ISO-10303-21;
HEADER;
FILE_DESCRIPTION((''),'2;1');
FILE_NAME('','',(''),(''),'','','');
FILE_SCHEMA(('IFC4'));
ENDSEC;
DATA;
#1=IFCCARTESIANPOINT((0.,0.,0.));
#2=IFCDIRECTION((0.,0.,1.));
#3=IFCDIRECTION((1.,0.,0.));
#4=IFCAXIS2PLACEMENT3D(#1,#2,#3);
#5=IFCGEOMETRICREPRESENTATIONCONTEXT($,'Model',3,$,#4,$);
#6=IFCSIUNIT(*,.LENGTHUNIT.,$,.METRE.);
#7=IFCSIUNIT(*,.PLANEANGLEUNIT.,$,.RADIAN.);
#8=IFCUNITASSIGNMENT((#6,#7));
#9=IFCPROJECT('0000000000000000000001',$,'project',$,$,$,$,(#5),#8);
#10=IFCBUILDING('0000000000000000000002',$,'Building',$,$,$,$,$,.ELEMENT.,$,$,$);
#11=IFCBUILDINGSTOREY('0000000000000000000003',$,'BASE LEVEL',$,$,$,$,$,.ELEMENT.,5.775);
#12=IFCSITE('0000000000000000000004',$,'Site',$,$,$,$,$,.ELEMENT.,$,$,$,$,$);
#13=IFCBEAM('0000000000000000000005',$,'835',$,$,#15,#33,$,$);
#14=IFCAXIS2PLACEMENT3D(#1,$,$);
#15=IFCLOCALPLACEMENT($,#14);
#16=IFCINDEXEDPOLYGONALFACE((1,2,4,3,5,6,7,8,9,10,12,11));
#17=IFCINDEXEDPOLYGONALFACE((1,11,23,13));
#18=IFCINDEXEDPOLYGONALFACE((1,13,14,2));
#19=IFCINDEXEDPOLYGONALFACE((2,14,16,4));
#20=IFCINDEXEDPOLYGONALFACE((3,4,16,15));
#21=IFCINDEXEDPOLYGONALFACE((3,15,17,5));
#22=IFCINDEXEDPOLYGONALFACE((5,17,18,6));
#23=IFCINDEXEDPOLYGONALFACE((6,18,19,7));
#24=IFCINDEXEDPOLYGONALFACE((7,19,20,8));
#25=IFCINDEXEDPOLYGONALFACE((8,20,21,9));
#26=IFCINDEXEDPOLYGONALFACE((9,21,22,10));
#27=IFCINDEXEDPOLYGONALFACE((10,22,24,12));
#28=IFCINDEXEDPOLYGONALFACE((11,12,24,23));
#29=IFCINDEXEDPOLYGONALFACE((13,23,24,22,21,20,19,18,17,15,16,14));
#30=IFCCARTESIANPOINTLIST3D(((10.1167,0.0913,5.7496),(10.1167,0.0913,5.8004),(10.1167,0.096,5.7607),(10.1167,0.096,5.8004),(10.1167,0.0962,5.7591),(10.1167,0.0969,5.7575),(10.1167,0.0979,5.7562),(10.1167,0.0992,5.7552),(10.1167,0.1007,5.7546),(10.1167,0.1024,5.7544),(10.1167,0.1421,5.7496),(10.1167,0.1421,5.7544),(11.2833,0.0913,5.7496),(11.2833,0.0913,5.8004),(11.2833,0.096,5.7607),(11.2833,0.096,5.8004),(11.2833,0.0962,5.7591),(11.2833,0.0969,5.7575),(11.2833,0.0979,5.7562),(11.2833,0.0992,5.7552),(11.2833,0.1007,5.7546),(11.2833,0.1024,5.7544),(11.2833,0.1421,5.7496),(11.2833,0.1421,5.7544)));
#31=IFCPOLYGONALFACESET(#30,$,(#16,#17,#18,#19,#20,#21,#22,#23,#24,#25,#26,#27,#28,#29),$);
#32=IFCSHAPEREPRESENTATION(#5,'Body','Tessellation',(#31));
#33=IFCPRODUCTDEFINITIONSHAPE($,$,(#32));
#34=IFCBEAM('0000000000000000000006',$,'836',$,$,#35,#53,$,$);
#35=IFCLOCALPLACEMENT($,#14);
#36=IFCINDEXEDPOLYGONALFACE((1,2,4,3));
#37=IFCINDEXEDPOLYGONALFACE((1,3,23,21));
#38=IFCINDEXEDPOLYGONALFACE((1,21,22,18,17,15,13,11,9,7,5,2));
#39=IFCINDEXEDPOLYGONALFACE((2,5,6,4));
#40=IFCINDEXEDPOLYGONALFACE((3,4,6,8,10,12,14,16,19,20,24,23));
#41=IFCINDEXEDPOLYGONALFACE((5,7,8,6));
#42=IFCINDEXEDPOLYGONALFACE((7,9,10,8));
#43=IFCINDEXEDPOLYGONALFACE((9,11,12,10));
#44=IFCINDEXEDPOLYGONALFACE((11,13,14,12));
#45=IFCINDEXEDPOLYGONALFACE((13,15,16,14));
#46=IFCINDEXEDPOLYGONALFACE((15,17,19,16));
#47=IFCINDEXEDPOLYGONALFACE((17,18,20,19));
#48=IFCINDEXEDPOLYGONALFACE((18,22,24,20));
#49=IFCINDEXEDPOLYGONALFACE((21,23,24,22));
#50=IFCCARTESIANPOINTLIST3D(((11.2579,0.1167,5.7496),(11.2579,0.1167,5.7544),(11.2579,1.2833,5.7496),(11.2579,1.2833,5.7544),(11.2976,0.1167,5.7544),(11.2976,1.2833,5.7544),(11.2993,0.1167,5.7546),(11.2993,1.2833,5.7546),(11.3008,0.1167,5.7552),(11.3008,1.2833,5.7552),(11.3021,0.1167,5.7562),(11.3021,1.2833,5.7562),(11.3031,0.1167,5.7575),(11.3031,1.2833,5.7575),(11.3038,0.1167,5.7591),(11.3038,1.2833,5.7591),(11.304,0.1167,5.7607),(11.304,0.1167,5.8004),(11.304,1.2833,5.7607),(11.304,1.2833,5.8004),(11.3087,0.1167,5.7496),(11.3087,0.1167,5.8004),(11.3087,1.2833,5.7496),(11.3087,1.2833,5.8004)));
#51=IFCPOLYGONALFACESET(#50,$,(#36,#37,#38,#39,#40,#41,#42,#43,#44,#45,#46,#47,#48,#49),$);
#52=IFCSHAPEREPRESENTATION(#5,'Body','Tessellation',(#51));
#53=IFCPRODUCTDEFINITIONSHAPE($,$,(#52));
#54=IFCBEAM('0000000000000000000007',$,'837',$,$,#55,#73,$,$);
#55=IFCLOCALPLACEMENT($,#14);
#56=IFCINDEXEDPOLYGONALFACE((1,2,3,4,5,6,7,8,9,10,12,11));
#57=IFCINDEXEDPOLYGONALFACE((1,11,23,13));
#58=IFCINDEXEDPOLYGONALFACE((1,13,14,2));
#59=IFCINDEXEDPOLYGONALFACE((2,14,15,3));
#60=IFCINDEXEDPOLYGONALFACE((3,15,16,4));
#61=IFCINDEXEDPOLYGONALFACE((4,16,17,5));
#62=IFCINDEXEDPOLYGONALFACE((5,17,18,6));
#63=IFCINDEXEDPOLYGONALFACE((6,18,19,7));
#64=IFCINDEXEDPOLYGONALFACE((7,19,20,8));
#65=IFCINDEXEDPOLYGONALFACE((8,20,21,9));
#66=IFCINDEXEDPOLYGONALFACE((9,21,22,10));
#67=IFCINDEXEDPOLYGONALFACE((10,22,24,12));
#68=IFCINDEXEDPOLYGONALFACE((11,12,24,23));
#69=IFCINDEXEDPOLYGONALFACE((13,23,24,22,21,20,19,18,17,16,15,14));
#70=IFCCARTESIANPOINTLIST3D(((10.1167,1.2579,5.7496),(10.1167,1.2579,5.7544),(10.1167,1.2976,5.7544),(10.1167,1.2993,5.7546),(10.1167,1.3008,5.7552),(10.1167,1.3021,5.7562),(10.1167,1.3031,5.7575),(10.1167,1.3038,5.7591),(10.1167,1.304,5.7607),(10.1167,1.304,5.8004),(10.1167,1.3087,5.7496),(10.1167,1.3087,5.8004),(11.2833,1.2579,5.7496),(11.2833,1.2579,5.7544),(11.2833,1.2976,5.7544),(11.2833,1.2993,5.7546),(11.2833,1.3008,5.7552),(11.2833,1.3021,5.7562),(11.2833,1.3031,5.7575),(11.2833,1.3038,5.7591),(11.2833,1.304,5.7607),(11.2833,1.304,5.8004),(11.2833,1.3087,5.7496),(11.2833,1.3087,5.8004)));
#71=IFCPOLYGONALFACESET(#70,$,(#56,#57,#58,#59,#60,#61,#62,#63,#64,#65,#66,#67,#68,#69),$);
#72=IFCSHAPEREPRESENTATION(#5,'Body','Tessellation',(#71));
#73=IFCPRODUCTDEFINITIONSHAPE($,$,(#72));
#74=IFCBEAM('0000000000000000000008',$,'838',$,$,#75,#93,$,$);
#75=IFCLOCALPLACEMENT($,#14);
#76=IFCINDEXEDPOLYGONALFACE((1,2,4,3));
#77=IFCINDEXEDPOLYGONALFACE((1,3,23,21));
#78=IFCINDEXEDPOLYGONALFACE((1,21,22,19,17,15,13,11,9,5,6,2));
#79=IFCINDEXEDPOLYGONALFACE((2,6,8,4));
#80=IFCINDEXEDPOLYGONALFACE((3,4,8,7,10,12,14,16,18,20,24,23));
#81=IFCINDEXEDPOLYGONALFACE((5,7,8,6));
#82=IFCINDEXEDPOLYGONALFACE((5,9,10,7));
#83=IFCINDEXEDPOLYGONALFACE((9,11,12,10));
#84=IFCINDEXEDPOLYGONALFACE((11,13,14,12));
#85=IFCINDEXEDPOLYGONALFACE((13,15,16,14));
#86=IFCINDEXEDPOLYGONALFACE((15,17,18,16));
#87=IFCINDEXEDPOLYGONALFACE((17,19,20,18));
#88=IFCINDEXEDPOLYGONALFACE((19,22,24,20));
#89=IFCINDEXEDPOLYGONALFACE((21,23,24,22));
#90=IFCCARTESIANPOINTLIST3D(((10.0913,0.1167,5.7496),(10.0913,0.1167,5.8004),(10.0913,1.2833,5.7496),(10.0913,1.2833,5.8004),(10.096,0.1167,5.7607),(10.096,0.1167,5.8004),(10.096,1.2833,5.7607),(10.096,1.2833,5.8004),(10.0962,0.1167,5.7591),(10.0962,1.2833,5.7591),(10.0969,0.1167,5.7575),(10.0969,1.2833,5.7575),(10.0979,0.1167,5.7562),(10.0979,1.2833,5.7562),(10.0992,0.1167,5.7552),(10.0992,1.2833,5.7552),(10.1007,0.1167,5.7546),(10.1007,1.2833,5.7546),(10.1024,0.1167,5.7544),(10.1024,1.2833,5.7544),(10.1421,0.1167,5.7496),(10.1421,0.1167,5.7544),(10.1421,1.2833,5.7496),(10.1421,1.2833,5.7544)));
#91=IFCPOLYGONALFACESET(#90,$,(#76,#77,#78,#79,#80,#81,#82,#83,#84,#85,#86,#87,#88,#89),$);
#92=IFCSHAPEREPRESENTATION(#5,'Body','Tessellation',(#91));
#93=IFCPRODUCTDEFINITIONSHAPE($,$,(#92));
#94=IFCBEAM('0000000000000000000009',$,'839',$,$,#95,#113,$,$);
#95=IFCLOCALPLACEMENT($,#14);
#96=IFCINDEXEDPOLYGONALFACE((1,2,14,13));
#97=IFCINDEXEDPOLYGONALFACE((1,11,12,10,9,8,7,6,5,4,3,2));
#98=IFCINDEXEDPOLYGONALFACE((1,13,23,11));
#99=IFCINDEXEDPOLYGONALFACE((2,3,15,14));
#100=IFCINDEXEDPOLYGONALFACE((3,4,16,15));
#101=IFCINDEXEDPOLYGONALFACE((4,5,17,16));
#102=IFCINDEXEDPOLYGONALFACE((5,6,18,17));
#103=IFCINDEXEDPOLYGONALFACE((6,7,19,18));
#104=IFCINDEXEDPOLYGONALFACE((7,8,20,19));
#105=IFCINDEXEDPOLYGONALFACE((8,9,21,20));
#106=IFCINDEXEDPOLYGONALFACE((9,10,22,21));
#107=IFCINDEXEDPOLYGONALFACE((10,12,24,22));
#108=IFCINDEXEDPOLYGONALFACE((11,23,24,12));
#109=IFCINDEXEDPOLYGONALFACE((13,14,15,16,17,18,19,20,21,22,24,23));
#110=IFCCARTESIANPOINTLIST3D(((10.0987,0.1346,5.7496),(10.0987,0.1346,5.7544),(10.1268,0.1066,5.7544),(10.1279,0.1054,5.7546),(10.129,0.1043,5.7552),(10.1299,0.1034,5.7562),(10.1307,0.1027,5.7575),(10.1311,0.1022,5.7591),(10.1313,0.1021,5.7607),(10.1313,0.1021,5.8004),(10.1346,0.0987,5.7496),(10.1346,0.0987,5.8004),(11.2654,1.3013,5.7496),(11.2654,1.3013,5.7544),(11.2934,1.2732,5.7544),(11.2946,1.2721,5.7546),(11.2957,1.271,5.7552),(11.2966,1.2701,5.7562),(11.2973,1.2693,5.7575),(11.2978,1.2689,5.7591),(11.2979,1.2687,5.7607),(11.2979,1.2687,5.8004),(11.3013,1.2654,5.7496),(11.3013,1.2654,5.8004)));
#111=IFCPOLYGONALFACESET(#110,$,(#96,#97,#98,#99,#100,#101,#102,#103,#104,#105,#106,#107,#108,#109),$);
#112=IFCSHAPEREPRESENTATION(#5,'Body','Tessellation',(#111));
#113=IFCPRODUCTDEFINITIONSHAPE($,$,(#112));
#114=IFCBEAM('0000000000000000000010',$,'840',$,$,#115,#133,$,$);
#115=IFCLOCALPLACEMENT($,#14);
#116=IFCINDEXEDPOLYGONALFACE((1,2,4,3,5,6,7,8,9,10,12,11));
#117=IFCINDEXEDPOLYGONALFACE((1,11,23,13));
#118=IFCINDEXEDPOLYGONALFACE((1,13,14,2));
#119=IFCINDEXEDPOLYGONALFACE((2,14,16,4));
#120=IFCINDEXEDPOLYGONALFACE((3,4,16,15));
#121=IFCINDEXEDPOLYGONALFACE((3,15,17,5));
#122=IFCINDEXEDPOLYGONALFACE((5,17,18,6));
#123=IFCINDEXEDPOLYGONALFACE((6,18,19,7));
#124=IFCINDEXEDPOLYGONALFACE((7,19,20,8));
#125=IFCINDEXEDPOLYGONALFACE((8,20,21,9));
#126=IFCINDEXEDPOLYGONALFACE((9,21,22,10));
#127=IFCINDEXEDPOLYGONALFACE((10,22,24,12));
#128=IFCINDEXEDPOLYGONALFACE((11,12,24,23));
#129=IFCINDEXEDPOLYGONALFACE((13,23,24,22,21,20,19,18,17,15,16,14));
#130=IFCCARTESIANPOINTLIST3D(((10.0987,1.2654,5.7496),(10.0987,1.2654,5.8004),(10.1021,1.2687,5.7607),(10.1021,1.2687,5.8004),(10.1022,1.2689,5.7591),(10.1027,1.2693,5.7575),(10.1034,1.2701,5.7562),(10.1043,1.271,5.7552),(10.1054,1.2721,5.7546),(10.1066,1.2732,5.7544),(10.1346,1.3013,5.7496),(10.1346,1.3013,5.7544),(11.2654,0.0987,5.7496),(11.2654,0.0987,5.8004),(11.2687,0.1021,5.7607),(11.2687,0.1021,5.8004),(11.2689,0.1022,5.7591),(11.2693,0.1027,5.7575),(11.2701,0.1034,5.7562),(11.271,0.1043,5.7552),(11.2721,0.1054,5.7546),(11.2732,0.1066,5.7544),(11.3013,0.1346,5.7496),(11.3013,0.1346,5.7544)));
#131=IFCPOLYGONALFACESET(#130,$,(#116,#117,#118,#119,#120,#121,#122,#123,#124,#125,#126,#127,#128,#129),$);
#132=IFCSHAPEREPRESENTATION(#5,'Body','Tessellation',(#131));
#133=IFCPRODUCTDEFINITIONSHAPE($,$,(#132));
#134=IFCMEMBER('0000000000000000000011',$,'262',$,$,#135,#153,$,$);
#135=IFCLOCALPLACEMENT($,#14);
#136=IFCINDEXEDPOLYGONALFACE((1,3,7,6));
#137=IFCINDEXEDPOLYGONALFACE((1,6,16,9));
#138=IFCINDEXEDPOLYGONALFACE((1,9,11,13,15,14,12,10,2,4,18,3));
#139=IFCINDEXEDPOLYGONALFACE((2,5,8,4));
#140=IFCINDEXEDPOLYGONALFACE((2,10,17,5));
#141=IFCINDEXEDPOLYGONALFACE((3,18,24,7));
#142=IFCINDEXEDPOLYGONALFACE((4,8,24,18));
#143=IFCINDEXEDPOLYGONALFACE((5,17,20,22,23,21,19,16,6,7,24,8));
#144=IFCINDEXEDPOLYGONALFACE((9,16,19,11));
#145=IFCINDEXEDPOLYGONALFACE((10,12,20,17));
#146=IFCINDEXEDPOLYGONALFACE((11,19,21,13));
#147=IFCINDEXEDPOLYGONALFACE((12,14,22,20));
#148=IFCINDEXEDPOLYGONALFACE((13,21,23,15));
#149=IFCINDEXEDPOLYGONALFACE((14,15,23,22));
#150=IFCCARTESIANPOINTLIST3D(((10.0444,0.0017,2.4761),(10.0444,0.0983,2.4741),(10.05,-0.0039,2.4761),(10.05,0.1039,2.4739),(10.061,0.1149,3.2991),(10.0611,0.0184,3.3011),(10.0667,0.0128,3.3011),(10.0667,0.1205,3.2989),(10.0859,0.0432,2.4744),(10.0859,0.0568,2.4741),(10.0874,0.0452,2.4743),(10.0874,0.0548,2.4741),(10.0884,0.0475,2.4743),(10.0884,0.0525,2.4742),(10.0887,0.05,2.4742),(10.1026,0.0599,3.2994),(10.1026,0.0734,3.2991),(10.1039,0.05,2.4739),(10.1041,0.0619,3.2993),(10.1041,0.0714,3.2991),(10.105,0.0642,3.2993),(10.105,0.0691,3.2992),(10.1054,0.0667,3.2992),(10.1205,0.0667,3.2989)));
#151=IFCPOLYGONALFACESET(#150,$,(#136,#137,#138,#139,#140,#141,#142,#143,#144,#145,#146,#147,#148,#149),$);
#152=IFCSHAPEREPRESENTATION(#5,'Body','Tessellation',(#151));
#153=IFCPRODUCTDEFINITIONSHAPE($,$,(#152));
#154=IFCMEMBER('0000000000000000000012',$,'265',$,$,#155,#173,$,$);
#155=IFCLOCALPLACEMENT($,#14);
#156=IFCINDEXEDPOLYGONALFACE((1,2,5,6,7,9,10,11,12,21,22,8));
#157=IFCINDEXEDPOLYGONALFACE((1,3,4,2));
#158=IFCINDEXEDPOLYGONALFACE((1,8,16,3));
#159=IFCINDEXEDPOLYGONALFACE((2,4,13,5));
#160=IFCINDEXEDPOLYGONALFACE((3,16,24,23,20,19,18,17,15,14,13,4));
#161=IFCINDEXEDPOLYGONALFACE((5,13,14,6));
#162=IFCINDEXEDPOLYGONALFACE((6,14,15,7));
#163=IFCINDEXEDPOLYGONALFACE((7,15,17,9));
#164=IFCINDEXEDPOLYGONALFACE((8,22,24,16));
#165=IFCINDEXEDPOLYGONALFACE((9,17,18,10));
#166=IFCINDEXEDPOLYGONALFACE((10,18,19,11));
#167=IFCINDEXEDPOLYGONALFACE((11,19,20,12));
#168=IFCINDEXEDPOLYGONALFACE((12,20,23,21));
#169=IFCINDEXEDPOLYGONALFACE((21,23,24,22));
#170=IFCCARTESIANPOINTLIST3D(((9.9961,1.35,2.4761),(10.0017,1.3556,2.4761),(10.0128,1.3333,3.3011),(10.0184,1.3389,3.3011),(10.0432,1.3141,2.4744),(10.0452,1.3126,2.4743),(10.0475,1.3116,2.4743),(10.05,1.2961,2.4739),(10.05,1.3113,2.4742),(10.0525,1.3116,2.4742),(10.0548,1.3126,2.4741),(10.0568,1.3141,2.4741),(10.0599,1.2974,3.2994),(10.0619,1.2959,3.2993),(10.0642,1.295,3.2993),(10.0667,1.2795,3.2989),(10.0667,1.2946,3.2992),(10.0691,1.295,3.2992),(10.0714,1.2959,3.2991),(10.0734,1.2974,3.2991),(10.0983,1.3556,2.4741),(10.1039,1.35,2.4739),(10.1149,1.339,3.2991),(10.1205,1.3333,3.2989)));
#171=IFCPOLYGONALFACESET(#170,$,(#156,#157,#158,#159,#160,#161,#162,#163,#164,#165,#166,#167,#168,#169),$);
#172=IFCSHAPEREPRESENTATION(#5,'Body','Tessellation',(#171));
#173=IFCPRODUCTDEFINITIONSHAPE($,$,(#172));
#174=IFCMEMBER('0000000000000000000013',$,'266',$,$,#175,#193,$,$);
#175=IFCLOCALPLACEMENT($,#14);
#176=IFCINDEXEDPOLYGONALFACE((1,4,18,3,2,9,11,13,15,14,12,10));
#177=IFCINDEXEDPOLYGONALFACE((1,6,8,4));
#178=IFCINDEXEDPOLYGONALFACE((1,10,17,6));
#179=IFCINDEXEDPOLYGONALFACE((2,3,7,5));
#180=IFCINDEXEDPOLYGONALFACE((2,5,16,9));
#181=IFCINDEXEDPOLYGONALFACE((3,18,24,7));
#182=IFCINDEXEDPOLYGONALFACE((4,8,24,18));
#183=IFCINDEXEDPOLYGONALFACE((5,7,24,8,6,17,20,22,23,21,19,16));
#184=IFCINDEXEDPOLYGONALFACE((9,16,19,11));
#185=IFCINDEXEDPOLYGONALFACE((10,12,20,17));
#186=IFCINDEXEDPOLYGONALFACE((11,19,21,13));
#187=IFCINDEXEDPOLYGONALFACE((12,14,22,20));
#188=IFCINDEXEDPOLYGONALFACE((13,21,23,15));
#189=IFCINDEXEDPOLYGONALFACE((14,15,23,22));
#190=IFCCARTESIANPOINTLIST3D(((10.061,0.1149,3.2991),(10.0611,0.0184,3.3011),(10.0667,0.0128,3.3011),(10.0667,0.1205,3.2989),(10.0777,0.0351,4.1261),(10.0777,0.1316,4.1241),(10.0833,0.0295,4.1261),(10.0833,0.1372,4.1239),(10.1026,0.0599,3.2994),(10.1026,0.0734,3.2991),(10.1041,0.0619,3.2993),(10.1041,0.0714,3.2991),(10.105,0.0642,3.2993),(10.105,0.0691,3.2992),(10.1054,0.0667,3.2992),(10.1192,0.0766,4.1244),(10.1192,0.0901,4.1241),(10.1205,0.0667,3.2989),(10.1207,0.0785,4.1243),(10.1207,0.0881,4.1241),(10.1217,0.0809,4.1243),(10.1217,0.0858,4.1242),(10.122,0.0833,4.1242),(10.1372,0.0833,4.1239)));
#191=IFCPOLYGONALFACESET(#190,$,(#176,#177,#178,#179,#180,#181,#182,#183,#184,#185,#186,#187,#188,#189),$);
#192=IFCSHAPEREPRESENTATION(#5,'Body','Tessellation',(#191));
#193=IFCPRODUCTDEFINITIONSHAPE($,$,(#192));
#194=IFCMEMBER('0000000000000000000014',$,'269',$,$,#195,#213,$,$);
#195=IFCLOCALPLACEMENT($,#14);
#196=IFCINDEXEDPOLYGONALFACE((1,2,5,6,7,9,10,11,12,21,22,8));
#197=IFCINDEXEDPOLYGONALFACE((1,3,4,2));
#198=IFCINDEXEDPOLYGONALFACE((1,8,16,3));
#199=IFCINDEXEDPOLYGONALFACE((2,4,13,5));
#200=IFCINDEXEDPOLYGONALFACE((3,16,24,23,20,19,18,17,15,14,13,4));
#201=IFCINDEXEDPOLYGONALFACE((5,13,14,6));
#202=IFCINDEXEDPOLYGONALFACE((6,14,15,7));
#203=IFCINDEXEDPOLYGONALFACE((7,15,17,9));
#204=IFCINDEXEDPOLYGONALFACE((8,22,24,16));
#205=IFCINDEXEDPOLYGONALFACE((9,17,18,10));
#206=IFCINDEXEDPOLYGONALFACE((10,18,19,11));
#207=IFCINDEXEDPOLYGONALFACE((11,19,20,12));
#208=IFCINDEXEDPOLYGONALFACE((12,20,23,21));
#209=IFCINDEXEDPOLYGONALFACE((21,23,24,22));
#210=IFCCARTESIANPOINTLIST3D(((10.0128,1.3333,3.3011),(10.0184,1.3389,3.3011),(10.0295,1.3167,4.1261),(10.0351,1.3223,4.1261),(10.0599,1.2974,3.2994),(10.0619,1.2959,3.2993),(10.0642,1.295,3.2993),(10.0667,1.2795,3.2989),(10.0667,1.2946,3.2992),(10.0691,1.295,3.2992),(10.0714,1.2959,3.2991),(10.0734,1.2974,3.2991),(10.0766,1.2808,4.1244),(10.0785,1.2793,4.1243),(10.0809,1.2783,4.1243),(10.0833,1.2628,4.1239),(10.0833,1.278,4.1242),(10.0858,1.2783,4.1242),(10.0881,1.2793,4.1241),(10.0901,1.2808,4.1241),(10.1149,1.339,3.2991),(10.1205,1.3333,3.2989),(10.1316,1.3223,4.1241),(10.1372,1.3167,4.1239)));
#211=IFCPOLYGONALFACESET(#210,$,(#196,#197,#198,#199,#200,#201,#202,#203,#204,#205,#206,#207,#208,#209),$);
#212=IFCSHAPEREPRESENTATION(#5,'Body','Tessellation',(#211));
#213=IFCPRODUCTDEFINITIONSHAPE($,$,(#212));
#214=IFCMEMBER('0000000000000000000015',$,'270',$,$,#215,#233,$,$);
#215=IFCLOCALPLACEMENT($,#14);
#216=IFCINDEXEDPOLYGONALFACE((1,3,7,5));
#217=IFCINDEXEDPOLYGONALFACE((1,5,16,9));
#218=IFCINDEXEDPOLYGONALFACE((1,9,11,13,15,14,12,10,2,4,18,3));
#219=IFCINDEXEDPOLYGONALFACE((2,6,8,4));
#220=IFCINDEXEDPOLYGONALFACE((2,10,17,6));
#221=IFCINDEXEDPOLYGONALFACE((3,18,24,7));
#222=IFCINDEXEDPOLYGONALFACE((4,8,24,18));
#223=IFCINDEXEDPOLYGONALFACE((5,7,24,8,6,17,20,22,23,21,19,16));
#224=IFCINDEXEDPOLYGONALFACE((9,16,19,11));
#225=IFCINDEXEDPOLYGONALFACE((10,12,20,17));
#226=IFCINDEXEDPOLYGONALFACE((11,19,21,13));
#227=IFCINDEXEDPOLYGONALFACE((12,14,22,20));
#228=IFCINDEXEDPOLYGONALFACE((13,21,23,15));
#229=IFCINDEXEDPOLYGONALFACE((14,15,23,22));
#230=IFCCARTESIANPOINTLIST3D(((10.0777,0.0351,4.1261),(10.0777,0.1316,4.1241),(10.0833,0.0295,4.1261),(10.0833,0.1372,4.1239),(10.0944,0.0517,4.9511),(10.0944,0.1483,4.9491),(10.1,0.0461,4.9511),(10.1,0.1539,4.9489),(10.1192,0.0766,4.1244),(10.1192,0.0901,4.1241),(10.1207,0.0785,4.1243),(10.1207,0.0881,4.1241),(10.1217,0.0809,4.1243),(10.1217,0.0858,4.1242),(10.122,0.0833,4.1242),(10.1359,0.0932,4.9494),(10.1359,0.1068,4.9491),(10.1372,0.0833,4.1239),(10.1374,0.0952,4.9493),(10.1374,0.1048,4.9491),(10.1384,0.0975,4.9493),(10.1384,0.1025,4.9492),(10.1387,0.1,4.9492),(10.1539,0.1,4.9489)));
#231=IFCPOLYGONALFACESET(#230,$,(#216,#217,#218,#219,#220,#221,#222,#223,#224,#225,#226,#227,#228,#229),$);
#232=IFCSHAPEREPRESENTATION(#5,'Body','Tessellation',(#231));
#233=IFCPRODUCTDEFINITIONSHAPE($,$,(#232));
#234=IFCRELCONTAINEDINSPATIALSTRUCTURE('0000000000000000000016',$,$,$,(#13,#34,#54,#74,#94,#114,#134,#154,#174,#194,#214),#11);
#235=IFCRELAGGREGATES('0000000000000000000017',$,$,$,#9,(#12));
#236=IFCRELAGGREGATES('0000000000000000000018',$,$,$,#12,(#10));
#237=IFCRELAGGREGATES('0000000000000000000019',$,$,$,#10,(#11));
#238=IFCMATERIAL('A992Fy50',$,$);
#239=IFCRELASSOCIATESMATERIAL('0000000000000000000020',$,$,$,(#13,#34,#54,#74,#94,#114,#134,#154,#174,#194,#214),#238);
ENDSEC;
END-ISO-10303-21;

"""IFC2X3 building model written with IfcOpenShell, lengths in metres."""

from ifc_helpers import new_model, si_unit, frame, origin_with_axes, origin_2d_with_axis, place, context, project, spatial, l_section, extrude, material, element, save


model = new_model("IFC2X3")

# Units and contexts
model_context = context("Model", 3, world=origin_with_axes())
ifc_project = project(units=[si_unit("LENGTHUNIT", "METRE"), si_unit("PLANEANGLEUNIT", "RADIAN")], contexts=[model_context])

# Site, building, storey
site = spatial("IfcSite", under=ifc_project, Name="Site", CompositionType="ELEMENT")
building = spatial("IfcBuilding", under=site, Name="Building", CompositionType="ELEMENT")
storey = spatial("IfcBuildingStorey", under=building, Name="BASE LEVEL", CompositionType="ELEMENT", Elevation=5.775)

# Beams
ifc_material = material(Name="A992Fy50")
for number, where, z_axis, x_axis, name in (
    (1, (10.1167, 0.1167, 5.775), (1.0, 0.0, 0.0), (0.0, 1.0, 0.0), "835"),
    (2, (11.2833, 0.1167, 5.775), (0.0, 1.0, 0.0), (-1.0, 0.0, 0.0), "836"),
    (3, (11.2833, 1.2833, 5.775), (-1.0, 0.0, 0.0), (0.0, -1.0, 0.0), "837"),
    (4, (10.1167, 1.2833, 5.775), (0.0, -1.0, 0.0), (1.0, 0.0, 0.0), "838"),
):
    element("IfcBeam", number, at=place(None, frame(where, z_axis=z_axis, x_axis=x_axis)), inside=storey, material=ifc_material, Name=name, context=model_context, shape_type="SweptSolid", body=[
        extrude(l_section(Depth=0.0508, Width=0.0508, Thickness=0.0048, FilletRadius=0.0063, at=origin_2d_with_axis()), origin_with_axes(), (0.0, 0.0, 1.0), 1.1667),
    ])
for number, where, z_axis, x_axis, name in (
    (5, (10.1167, 0.1167, 5.775), (0.707107, 0.707107, 0.0), (-0.707107, 0.707107, 0.0), "839"),
    (6, (10.1167, 1.2833, 5.775), (0.707107, -0.707107, 0.0), (0.707107, 0.707107, 0.0), "840"),
):
    element("IfcBeam", number, at=place(None, frame(where, z_axis=z_axis, x_axis=x_axis)), inside=storey, material=ifc_material, Name=name, context=model_context, shape_type="SweptSolid", body=[
        extrude(l_section(Depth=0.0508, Width=0.0508, Thickness=0.0048, FilletRadius=0.0063, at=origin_2d_with_axis()), origin_with_axes(), (0.0, 0.0, 1.0), 1.6499),
    ])

# Members
for number, where, z_axis, x_axis, name in (
    (7, (10.05, 0.05, 2.475), (0.020194, 0.020194, 0.999592), (-0.707107, 0.707107, 0.0), "262"),
    (8, (10.05, 1.35, 2.475), (0.020194, -0.020194, 0.999592), (0.707107, 0.707107, 0.0), "265"),
    (9, (10.0667, 0.0667, 3.3), (0.020194, 0.020194, 0.999592), (-0.707107, 0.707107, 0.0), "266"),
    (10, (10.0667, 1.3333, 3.3), (0.020194, -0.020194, 0.999592), (0.707107, 0.707107, 0.0), "269"),
    (11, (10.0833, 0.0833, 4.125), (0.020194, 0.020194, 0.999592), (-0.707107, 0.707107, 0.0), "270"),
):
    element("IfcMember", number, at=place(None, frame(where, z_axis=z_axis, x_axis=x_axis)), inside=storey, material=ifc_material, Name=name, context=model_context, shape_type="SweptSolid", body=[
        extrude(l_section(Depth=0.0762, Width=0.0762, Thickness=0.0079, FilletRadius=0.0096, at=origin_2d_with_axis()), origin_with_axes(), (0.0, 0.0, 1.0), 0.8253),
    ])

save(model, "model.ifc")
